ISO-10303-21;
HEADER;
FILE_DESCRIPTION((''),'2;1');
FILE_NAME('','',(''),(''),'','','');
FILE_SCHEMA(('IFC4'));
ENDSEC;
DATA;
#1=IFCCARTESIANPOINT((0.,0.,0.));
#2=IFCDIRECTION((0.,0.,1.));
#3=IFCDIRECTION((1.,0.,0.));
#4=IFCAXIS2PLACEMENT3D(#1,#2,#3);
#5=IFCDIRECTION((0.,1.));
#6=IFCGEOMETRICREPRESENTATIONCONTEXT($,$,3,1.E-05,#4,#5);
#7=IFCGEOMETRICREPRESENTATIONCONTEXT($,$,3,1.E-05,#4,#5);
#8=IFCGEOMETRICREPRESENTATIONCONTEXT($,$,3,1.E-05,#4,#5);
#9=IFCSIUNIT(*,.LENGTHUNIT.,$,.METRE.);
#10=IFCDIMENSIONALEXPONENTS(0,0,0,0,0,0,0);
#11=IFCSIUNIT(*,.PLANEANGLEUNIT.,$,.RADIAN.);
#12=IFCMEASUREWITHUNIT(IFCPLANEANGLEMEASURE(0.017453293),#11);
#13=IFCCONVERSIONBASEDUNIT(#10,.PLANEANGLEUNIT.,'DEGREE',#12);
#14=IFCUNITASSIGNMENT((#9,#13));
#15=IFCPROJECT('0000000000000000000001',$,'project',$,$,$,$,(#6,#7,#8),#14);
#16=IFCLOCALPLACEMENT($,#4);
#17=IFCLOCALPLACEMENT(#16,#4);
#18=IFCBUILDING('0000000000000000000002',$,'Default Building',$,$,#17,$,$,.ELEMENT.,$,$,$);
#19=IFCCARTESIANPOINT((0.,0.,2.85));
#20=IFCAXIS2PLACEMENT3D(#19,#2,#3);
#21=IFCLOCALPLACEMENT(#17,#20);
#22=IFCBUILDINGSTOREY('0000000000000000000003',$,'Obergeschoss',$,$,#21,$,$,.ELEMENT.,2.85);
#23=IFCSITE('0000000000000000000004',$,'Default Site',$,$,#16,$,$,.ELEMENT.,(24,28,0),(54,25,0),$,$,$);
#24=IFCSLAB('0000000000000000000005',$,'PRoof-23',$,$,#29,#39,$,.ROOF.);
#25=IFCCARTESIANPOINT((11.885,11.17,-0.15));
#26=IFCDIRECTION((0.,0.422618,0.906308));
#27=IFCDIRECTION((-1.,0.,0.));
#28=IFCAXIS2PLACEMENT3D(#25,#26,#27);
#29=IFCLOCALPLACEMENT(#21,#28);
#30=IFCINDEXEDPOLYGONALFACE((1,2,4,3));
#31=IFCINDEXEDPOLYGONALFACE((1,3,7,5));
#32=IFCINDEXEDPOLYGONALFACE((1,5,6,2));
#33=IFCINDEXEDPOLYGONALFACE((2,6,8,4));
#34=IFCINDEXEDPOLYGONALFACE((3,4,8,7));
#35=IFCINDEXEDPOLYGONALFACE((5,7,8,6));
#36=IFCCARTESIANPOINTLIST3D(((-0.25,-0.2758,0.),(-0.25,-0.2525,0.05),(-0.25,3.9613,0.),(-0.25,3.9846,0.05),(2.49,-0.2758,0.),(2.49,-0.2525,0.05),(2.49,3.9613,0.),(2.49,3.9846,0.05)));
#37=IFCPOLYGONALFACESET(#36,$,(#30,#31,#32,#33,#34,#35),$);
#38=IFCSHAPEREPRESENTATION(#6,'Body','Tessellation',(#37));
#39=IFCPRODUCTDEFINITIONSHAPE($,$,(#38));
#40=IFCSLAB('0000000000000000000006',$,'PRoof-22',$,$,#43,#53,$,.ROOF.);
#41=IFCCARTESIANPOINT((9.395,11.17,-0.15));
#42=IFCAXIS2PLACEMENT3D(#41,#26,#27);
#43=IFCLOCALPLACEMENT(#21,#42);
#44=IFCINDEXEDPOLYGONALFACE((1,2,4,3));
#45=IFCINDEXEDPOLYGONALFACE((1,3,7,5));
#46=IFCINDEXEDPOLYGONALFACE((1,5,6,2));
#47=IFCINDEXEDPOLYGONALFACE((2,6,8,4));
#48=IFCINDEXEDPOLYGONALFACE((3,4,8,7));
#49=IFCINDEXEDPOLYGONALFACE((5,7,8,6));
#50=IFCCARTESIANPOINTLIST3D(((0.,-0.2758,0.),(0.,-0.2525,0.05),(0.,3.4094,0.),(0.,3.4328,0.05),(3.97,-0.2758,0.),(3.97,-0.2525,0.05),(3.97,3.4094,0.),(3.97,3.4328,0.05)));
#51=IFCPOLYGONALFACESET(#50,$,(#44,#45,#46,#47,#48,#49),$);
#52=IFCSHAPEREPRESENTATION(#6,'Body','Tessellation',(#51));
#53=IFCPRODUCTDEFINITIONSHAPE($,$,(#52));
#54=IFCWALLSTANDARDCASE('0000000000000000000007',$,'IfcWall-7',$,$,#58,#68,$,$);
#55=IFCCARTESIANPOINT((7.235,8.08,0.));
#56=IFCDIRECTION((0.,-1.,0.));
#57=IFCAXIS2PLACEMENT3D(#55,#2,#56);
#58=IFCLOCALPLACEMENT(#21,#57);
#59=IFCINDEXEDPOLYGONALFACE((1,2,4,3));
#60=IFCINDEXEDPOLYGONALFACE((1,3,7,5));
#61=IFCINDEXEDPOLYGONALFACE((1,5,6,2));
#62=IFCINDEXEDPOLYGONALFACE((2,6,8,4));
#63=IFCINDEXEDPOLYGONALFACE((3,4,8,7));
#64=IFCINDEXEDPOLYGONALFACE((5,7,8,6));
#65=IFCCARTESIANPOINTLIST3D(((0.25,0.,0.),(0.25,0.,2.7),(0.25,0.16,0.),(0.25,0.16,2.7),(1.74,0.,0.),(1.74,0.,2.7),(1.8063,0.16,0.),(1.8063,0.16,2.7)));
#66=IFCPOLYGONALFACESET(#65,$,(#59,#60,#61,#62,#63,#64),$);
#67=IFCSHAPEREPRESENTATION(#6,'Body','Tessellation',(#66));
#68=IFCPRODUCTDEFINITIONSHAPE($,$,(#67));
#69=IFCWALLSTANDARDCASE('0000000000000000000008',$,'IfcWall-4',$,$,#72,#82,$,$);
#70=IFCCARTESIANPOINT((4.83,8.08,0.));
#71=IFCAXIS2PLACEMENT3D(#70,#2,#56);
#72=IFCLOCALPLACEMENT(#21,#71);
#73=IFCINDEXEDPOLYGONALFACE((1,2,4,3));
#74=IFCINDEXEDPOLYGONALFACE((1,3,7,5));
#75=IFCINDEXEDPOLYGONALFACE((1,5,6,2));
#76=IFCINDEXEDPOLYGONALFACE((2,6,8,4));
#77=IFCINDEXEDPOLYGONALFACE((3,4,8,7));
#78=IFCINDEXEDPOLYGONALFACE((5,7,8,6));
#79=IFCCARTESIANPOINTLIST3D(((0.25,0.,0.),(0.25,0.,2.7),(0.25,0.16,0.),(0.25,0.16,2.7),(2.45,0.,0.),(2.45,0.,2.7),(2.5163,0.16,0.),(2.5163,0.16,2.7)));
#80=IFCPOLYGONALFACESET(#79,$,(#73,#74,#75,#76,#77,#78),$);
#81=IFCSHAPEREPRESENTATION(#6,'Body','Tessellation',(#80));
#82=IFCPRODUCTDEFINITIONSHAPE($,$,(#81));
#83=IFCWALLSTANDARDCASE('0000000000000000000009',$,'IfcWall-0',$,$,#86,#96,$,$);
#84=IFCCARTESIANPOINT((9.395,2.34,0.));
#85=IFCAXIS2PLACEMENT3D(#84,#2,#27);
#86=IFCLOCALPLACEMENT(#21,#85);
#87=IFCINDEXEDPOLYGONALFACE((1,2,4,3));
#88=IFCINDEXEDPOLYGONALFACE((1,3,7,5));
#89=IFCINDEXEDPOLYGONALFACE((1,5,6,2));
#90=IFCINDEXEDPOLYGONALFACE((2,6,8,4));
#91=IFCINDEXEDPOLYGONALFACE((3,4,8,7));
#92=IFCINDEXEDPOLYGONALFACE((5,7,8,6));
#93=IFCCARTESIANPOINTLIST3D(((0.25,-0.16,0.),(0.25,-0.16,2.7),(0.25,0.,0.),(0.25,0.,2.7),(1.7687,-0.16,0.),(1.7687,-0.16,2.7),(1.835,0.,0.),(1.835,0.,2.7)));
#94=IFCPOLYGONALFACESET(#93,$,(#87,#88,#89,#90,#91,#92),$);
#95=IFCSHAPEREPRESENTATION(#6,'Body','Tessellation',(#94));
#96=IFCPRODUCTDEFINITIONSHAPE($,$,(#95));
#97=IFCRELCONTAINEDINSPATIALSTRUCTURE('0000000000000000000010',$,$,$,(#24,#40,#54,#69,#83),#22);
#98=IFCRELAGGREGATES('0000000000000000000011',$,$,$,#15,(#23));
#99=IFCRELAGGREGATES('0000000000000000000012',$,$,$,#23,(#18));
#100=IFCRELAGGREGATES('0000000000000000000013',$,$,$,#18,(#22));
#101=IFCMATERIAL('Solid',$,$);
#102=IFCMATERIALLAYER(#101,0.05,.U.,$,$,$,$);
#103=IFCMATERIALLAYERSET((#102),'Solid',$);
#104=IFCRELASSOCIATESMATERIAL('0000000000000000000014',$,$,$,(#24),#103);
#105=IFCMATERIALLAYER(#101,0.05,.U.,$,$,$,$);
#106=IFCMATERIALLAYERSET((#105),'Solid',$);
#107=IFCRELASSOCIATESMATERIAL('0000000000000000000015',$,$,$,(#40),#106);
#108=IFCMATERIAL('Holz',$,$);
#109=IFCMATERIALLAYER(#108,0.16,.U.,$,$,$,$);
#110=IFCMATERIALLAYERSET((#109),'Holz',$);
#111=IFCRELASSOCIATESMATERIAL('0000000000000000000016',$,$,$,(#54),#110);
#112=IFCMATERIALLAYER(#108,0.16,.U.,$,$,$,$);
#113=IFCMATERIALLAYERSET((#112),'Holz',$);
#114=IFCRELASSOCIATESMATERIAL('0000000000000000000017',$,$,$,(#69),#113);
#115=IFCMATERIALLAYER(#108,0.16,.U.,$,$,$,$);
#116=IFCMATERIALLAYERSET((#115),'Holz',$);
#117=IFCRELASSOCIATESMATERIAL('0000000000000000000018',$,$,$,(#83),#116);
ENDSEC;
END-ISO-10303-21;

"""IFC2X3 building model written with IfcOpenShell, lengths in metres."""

from ifc_helpers import new_model, entity, si_unit, converted_unit, direction, frame, origin_with_axes, place, context, project, spatial, polyline, outline, extrude, material, layer, layer_set, layer_usage, element, save


model = new_model("IFC2X3")

# Units and contexts
context_of_model_1 = context(None, 3, precision=1e-05, world=origin_with_axes(), true_north=direction((0.0, 1.0)))
context_of_model_2 = context(None, 3, precision=1e-05, world=origin_with_axes(), true_north=direction((0.0, 1.0)))
context_of_model_3 = context(None, 3, precision=1e-05, world=origin_with_axes(), true_north=direction((0.0, 1.0)))
ifc_project = project(units=[si_unit("LENGTHUNIT", "METRE"), converted_unit("PLANEANGLEUNIT", "DEGREE", entity("IfcPlaneAngleMeasure", 0.017453293), si_unit("PLANEANGLEUNIT", "RADIAN"), dimensions=[0, 0, 0, 0, 0, 0, 0])], contexts=[context_of_model_1, context_of_model_2, context_of_model_3])

# Site, building, storey
site_placement = place(None, origin_with_axes())
site = spatial("IfcSite", under=ifc_project, at=site_placement, Name="Default Site", CompositionType="ELEMENT", RefLatitude=(24, 28, 0), RefLongitude=(54, 25, 0))
building_placement = place(site_placement, origin_with_axes())
building = spatial("IfcBuilding", under=site, at=building_placement, Name="Default Building", CompositionType="ELEMENT")
storey_placement = place(building_placement, frame((0.0, 0.0, 2.85), z_axis=(0.0, 0.0, 1.0), x_axis=(1.0, 0.0, 0.0)))
storey = spatial("IfcBuildingStorey", under=building, at=storey_placement, Name="Obergeschoss", CompositionType="ELEMENT", Elevation=2.85)

# Shared definitions
ifc_material_1 = material(Name="Solid")

# Slabs
ifc_layer_1 = layer(ifc_material_1, 0.05, ventilated="UNKNOWN")
ifc_layer_set_1 = layer_set([ifc_layer_1], Name="Solid")
ifc_layer_usage_1 = layer_usage(ifc_layer_set_1, "AXIS3", "NEGATIVE", 0.05)
slab_1_placement = place(storey_placement, frame((11.885, 11.17, -0.15), z_axis=(0.0, 0.422618, 0.906308), x_axis=(-1.0, 0.0, 0.0)))
element("IfcSlab", 1, at=slab_1_placement, inside=storey, material=ifc_layer_usage_1, Name="PRoof-23", PredefinedType="ROOF", context=context_of_model_1, shape_type="SweptSolid", body=[
    extrude(outline(polyline([(2.49, -0.2758), (-0.25, -0.2758), (-0.25, 3.9613), (2.49, 3.9613), (2.49, -0.2758)])), origin_with_axes(), (0.0, 0.422618, 0.906308), 0.0552),
])
ifc_layer_2 = layer(ifc_material_1, 0.05, ventilated="UNKNOWN")
ifc_layer_set_2 = layer_set([ifc_layer_2], Name="Solid")
ifc_layer_usage_2 = layer_usage(ifc_layer_set_2, "AXIS3", "NEGATIVE", 0.05)
slab_2_placement = place(storey_placement, frame((9.395, 11.17, -0.15), z_axis=(0.0, 0.422618, 0.906308), x_axis=(-1.0, 0.0, 0.0)))
element("IfcSlab", 2, at=slab_2_placement, inside=storey, material=ifc_layer_usage_2, Name="PRoof-22", PredefinedType="ROOF", context=context_of_model_1, shape_type="SweptSolid", body=[
    extrude(outline(polyline([(0.0, 3.4094), (3.97, 3.4094), (3.97, -0.2758), (0.0, -0.2758), (0.0, 3.4094)])), origin_with_axes(), (0.0, 0.422618, 0.906308), 0.0552),
])

# Shared definitions
ifc_material_2 = material(Name="Holz")

# Walls
ifc_layer_3 = layer(ifc_material_2, 0.16, ventilated="UNKNOWN")
ifc_layer_set_3 = layer_set([ifc_layer_3], Name="Holz")
ifc_layer_usage_3 = layer_usage(ifc_layer_set_3, "AXIS2", "POSITIVE", 0.0)
wall_1_placement = place(storey_placement, frame((7.235, 8.08, 0.0), z_axis=(0.0, 0.0, 1.0), x_axis=(0.0, -1.0, 0.0)))
element("IfcWallStandardCase", 3, at=wall_1_placement, inside=storey, material=ifc_layer_usage_3, Name="IfcWall-7", context=context_of_model_1, shape_type="SweptSolid", body=[
    extrude(outline(polyline([(0.25, 0.0), (1.74, 0.0), (1.8063, 0.16), (0.25, 0.16), (0.25, 0.0)])), origin_with_axes(), (0.0, 0.0, 1.0), 2.7),
])
ifc_layer_4 = layer(ifc_material_2, 0.16, ventilated="UNKNOWN")
ifc_layer_set_4 = layer_set([ifc_layer_4], Name="Holz")
ifc_layer_usage_4 = layer_usage(ifc_layer_set_4, "AXIS2", "POSITIVE", 0.0)
wall_2_placement = place(storey_placement, frame((4.83, 8.08, 0.0), z_axis=(0.0, 0.0, 1.0), x_axis=(0.0, -1.0, 0.0)))
element("IfcWallStandardCase", 4, at=wall_2_placement, inside=storey, material=ifc_layer_usage_4, Name="IfcWall-4", context=context_of_model_1, shape_type="SweptSolid", body=[
    extrude(outline(polyline([(0.25, 0.0), (2.45, 0.0), (2.5163, 0.16), (0.25, 0.16), (0.25, 0.0)])), origin_with_axes(), (0.0, 0.0, 1.0), 2.7),
])
ifc_layer_5 = layer(ifc_material_2, 0.16, ventilated="UNKNOWN")
ifc_layer_set_5 = layer_set([ifc_layer_5], Name="Holz")
ifc_layer_usage_5 = layer_usage(ifc_layer_set_5, "AXIS2", "NEGATIVE", 0.0)
wall_3_placement = place(storey_placement, frame((9.395, 2.34, 0.0), z_axis=(0.0, 0.0, 1.0), x_axis=(-1.0, 0.0, 0.0)))
element("IfcWallStandardCase", 5, at=wall_3_placement, inside=storey, material=ifc_layer_usage_5, Name="IfcWall-0", context=context_of_model_1, shape_type="SweptSolid", body=[
    extrude(outline(polyline([(0.25, -0.16), (1.7687, -0.16), (1.835, 0.0), (0.25, 0.0), (0.25, -0.16)])), origin_with_axes(), (0.0, 0.0, 1.0), 2.7),
])

save(model, "model.ifc")
